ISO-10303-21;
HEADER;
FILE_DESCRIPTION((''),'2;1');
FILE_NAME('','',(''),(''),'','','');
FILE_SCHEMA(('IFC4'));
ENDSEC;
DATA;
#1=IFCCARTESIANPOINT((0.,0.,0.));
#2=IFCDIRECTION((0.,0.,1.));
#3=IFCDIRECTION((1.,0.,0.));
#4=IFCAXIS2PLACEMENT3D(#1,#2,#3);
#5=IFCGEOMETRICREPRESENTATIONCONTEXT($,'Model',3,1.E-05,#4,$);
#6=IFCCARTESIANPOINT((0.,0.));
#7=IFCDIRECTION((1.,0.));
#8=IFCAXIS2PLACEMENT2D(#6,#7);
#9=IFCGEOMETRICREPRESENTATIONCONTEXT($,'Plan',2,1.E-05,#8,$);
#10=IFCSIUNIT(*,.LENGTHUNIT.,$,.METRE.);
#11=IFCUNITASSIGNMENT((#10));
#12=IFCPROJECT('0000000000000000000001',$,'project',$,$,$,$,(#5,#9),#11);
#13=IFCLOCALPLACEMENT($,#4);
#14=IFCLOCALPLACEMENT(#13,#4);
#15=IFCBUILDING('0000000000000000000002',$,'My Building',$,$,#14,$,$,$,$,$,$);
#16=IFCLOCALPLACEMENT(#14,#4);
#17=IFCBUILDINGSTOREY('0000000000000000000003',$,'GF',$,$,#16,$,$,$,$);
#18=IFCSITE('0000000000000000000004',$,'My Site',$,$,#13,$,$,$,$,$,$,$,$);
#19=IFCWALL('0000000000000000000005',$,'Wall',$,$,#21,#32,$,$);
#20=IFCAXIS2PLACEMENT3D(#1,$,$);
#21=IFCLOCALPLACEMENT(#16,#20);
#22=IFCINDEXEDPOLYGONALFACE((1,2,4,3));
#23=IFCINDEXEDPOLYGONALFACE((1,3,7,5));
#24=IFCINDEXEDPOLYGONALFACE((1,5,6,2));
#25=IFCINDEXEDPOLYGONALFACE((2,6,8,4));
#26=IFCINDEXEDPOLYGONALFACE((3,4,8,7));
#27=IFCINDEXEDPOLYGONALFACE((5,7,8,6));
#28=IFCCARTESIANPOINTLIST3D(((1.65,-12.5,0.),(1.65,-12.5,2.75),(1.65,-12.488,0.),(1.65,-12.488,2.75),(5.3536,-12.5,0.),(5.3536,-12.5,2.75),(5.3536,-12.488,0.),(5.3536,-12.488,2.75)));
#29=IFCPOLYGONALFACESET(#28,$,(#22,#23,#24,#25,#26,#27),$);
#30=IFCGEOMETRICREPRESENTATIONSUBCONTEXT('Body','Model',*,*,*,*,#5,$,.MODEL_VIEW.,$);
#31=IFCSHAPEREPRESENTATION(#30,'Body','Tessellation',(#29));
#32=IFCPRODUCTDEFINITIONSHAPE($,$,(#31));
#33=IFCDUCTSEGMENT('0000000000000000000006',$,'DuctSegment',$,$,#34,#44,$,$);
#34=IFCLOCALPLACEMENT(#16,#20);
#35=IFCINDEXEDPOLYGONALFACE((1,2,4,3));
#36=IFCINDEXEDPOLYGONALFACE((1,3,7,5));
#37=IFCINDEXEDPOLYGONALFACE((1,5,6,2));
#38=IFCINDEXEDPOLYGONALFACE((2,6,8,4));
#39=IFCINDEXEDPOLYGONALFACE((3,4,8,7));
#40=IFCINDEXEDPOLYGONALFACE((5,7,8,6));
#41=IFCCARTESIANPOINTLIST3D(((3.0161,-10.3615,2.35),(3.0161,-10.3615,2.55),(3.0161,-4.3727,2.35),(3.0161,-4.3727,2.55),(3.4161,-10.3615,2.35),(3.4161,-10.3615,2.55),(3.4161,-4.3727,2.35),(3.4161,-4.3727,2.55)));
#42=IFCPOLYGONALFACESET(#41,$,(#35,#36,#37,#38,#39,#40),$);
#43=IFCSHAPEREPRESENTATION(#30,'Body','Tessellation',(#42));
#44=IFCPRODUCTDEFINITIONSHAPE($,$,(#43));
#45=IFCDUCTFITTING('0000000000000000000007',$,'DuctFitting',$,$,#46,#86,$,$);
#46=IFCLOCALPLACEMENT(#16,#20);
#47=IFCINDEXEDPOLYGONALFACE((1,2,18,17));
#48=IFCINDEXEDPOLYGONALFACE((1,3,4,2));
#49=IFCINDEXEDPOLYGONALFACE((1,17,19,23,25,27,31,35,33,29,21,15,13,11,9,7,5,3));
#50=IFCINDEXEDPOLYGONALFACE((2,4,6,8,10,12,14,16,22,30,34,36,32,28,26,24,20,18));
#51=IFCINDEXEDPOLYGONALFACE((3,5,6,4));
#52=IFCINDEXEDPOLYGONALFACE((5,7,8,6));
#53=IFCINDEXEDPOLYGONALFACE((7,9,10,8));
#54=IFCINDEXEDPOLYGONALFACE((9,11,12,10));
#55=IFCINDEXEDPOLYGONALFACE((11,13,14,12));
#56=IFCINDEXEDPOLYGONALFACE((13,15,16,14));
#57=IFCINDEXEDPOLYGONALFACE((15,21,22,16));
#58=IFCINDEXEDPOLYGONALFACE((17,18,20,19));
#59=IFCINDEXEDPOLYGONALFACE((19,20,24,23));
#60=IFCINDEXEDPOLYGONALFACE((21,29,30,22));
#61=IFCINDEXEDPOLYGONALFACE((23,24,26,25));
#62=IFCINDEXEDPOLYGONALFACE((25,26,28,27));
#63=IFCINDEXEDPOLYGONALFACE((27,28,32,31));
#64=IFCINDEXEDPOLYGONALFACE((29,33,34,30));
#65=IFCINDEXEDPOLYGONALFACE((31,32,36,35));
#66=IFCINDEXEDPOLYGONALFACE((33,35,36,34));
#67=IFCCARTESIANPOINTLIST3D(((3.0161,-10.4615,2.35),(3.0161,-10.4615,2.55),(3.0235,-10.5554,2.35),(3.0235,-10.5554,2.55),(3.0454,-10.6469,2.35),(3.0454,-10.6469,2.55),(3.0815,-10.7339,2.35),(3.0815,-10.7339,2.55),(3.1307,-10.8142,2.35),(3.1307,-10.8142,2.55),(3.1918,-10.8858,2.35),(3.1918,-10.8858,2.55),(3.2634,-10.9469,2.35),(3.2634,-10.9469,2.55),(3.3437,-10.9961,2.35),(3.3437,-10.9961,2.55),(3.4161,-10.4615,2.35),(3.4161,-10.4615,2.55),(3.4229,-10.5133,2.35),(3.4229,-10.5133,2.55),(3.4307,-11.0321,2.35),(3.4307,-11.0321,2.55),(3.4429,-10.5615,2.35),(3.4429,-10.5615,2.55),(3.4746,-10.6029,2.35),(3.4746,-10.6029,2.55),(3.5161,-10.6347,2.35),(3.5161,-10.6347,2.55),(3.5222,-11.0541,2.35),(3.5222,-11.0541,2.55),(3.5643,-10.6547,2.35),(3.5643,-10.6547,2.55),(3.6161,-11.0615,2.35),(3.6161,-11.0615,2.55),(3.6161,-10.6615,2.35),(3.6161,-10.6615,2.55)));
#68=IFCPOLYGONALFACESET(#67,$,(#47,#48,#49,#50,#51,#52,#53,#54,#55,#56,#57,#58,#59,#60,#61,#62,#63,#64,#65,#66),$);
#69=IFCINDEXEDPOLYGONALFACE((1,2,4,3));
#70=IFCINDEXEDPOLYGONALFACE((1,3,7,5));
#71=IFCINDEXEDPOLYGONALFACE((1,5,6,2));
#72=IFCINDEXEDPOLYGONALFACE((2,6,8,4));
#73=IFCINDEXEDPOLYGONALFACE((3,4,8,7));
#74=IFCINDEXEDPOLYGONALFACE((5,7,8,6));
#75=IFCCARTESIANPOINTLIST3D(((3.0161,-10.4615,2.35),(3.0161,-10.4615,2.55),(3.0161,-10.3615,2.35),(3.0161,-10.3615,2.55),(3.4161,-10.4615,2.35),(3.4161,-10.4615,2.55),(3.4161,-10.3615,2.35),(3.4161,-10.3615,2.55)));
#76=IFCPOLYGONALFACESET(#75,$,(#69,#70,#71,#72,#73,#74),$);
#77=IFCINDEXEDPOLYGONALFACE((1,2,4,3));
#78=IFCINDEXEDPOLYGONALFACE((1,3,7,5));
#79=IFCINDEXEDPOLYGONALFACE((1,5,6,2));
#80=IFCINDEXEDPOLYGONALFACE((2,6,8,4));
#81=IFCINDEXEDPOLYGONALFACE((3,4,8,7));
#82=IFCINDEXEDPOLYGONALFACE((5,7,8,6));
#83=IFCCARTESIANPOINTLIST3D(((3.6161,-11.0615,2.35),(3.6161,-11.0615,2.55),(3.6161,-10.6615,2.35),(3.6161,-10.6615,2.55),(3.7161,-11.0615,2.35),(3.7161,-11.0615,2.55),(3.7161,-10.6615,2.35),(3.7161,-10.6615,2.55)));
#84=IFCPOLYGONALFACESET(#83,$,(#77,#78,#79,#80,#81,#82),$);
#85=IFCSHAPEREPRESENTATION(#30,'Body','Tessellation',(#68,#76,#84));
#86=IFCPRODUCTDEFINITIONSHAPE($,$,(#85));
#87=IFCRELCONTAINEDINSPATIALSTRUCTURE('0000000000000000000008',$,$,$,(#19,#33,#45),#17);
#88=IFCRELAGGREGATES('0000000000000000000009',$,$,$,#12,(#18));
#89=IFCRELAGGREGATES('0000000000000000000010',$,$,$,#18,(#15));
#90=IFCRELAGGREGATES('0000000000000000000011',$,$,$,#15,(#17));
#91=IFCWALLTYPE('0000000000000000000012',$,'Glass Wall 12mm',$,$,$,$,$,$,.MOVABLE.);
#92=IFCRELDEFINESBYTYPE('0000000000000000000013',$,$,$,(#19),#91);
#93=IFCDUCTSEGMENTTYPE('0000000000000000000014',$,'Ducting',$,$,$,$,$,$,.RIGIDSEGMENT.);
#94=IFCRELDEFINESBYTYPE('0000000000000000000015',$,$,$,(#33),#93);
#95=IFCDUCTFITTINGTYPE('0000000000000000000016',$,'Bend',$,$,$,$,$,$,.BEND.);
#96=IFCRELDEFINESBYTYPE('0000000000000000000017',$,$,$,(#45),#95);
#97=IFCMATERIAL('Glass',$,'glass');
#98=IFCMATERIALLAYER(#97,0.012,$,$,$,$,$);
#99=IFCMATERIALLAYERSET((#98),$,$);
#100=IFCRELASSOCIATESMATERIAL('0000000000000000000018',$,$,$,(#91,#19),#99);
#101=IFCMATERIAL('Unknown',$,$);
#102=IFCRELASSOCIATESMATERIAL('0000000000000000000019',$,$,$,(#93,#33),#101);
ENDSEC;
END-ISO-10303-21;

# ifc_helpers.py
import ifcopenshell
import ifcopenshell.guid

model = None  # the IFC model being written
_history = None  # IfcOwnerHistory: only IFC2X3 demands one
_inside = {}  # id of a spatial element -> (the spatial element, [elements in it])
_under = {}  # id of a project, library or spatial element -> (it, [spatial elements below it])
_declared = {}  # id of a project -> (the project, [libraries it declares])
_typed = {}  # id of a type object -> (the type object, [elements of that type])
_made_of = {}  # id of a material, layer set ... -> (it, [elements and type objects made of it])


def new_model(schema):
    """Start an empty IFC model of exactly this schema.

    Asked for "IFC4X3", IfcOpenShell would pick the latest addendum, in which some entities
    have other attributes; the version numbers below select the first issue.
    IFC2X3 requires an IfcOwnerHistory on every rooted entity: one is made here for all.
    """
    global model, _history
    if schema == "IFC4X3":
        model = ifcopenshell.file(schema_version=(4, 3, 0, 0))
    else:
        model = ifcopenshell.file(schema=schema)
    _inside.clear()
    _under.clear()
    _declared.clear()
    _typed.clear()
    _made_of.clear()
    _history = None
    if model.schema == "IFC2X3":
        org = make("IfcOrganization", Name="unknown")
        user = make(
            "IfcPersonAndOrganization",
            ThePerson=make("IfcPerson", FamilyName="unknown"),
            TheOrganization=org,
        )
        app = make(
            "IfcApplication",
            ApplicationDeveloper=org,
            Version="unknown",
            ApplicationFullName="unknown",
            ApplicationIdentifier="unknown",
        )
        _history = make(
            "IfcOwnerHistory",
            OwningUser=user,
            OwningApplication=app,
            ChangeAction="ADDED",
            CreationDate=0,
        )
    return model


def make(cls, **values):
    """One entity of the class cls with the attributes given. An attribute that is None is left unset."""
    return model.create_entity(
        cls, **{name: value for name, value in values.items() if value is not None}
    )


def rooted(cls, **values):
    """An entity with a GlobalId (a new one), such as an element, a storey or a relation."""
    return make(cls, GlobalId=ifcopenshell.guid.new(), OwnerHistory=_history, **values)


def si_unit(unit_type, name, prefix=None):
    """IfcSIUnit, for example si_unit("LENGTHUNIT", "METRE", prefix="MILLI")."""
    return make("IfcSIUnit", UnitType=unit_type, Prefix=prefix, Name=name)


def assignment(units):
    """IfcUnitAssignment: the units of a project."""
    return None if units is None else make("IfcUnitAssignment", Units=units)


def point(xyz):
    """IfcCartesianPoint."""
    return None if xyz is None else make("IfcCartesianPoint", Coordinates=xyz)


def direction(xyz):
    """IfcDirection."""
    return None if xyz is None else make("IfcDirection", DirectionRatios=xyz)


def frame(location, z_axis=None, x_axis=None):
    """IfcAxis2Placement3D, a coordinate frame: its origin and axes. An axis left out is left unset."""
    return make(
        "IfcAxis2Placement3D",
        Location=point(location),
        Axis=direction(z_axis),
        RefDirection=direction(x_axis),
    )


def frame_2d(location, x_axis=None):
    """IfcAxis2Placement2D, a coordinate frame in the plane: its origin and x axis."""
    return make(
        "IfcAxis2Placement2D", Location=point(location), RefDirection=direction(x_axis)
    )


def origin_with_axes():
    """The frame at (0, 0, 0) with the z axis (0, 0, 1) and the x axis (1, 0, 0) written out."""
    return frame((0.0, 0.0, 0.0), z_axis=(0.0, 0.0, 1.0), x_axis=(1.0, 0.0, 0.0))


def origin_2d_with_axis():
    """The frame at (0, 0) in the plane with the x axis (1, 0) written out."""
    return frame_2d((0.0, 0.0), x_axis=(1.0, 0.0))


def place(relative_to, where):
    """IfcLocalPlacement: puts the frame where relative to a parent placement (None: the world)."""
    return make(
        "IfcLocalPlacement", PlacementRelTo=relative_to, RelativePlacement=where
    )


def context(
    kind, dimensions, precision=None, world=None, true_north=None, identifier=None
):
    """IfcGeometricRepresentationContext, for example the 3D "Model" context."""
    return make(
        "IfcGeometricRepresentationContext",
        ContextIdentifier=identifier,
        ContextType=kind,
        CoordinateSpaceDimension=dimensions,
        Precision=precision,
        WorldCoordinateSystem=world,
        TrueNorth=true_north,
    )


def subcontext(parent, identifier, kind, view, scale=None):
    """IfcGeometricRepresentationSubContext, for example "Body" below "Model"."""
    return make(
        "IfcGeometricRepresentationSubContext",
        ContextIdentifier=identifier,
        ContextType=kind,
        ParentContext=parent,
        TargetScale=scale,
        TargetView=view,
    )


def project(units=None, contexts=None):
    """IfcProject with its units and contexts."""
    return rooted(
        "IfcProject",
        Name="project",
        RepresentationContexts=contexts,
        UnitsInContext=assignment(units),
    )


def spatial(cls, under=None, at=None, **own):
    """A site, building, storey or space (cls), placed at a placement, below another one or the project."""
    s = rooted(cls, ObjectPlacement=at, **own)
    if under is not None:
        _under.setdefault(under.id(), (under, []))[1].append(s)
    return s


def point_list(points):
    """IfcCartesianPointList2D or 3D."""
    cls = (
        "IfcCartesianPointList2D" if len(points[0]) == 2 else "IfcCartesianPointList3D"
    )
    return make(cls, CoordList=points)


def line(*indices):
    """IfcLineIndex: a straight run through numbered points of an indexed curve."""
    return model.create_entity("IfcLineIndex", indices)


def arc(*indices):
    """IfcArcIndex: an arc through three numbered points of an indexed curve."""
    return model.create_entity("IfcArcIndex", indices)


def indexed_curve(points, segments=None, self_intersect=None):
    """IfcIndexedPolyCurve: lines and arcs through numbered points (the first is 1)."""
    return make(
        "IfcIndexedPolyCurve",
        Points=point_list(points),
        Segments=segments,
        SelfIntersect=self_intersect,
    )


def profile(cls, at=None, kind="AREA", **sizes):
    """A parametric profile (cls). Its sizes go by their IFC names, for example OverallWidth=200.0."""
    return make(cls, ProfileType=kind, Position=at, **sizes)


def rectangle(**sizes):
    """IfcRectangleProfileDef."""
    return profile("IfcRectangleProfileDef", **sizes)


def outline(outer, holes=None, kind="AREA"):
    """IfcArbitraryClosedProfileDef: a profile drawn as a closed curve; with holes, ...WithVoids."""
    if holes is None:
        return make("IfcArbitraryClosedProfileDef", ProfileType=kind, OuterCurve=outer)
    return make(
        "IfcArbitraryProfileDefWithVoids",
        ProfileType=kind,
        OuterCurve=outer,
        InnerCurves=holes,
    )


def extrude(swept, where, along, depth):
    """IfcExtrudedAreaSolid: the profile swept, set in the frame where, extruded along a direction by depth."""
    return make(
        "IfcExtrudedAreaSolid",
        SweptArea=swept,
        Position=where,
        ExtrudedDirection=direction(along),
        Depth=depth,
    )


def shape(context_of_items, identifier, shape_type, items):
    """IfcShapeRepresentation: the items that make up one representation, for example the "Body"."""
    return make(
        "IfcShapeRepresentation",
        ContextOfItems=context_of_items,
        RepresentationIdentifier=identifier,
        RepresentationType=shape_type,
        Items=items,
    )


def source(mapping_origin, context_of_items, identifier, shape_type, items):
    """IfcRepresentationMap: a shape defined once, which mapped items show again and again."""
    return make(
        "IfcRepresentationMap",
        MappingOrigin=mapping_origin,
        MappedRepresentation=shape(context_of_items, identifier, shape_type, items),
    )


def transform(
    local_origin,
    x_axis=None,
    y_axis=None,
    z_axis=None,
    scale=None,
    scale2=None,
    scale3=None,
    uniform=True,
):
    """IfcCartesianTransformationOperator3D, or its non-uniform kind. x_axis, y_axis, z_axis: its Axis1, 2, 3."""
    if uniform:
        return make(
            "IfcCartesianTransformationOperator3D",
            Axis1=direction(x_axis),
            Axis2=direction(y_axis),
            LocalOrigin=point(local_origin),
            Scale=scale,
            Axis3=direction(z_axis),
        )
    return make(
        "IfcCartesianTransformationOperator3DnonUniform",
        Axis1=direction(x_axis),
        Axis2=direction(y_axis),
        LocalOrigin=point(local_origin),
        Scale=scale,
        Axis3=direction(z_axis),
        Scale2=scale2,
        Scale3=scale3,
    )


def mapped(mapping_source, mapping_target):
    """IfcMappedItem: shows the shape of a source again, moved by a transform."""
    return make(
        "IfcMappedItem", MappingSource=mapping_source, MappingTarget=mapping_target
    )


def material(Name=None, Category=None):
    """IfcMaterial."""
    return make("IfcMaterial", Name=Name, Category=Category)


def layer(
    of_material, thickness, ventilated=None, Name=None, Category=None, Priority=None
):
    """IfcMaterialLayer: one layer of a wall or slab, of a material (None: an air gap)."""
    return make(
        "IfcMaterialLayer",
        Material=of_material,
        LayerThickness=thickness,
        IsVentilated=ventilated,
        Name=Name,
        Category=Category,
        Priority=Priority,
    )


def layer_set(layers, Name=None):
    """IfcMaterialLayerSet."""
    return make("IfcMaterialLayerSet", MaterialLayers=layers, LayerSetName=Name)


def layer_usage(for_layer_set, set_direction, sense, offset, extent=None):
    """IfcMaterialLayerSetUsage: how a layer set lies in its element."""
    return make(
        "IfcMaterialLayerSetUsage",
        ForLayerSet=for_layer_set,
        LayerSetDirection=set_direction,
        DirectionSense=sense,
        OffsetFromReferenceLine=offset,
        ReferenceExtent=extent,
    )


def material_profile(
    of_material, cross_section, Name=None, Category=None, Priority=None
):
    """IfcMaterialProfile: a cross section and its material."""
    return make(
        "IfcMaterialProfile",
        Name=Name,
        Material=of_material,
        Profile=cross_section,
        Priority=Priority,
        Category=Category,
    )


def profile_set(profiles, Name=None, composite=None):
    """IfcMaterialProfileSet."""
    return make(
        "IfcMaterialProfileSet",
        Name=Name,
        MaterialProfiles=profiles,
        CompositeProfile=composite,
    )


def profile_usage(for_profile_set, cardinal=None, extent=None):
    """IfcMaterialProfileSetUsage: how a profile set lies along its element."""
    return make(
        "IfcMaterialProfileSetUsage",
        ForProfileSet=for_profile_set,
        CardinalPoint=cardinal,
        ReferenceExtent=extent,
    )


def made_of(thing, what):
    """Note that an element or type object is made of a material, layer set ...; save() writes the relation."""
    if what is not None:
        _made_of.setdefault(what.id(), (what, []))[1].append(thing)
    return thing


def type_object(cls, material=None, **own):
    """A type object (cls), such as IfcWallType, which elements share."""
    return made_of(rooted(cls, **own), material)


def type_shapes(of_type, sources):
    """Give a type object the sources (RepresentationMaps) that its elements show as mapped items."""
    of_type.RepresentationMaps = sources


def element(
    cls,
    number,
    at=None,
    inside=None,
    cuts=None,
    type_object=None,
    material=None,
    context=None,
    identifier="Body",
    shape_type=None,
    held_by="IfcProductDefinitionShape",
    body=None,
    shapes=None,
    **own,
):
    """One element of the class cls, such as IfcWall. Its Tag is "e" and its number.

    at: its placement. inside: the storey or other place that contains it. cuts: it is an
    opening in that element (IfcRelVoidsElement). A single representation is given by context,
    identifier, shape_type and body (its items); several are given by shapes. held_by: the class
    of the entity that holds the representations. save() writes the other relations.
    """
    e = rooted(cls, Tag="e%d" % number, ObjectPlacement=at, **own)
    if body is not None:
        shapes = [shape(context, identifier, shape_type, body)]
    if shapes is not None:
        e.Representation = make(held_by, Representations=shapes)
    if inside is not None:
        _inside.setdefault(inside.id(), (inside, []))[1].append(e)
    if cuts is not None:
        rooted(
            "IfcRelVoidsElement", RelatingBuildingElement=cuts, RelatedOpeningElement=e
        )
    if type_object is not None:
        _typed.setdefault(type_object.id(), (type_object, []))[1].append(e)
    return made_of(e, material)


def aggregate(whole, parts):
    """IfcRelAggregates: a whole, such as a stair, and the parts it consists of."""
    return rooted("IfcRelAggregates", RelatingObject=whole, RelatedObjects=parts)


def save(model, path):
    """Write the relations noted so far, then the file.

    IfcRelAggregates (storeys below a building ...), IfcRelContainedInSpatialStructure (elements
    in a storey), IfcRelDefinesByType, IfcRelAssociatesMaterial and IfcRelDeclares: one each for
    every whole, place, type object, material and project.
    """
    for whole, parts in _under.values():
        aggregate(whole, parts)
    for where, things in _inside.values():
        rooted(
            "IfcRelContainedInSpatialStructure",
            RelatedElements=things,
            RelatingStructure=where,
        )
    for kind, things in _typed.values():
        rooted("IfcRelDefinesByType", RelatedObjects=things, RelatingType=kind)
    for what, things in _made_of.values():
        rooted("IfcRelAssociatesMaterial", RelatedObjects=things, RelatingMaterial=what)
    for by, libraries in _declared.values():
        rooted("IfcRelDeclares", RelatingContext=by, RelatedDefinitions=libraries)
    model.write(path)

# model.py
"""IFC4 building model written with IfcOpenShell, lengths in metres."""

from ifc_helpers import new_model, si_unit, frame, origin_with_axes, origin_2d_with_axis, place, context, subcontext, project, spatial, line, arc, indexed_curve, rectangle, outline, extrude, source, transform, mapped, material, layer, layer_set, layer_usage, material_profile, profile_set, profile_usage, type_object, type_shapes, element, save


model = new_model("IFC4")

# Units and contexts
model_context = context("Model", 3, precision=1e-05, world=origin_with_axes())
plan_context = context("Plan", 2, precision=1e-05, world=origin_2d_with_axis())
body_context_1 = subcontext(model_context, "Body", "Model", "MODEL_VIEW")
ifc_project = project(units=[si_unit("LENGTHUNIT", "METRE")], contexts=[model_context, plan_context])

# Site, building, storey
site_placement = place(None, origin_with_axes())
site = spatial("IfcSite", under=ifc_project, at=site_placement, Name="My Site")
building_placement = place(site_placement, origin_with_axes())
building = spatial("IfcBuilding", under=site, at=building_placement, Name="My Building")
storey_placement = place(building_placement, origin_with_axes())
storey = spatial("IfcBuildingStorey", under=building, at=storey_placement, Name="GF")

# Shared definitions
ifc_material_1 = material(Name="Unknown")

# Wall
ifc_material_2 = material(Name="Glass", Category="glass")
ifc_layer_1 = layer(ifc_material_2, 0.012)
ifc_layer_set_1 = layer_set([ifc_layer_1])
ifc_layer_usage_1 = layer_usage(ifc_layer_set_1, "AXIS2", "POSITIVE", 0.0)
wall_type_1 = type_object("IfcWallType", Name="Glass Wall 12mm", PredefinedType="MOVABLE", material=ifc_layer_set_1)
wall_1_placement = place(storey_placement, frame((1.65, -12.5, 0.0), z_axis=(0.0, 0.0, 1.0), x_axis=(1.0, 0.0, 0.0)))
element("IfcWall", 1, at=wall_1_placement, inside=storey, type_object=wall_type_1, material=ifc_layer_usage_1, Name="Wall", context=body_context_1, shape_type="SweptSolid", body=[
    extrude(outline(indexed_curve([(0.0, 0.0), (0.0, 0.012), (3.7036, 0.012), (3.7036, 0.0)], segments=[line(1, 2, 3, 4, 1)])), origin_with_axes(), (0.0, 0.0, 1.0), 2.75),
])

# Duct segment
ifc_material_profile_1 = material_profile(ifc_material_1, rectangle(XDim=0.4, YDim=0.2))
ifc_profile_set_1 = profile_set([ifc_material_profile_1])
ifc_profile_usage_1 = profile_usage(ifc_profile_set_1, cardinal=4)
duct_segment_type = type_object("IfcDuctSegmentType", Name="Ducting", PredefinedType="RIGIDSEGMENT", material=ifc_profile_set_1)
duct_segment_placement = place(storey_placement, frame((3.0161, -10.3615, 2.45), z_axis=(0.0, 1.0, 0.0), x_axis=(-1.0, 0.0, 0.0)))
element("IfcDuctSegment", 2, at=duct_segment_placement, inside=storey, type_object=duct_segment_type, material=ifc_profile_usage_1, Name="DuctSegment", context=body_context_1, shape_type="SweptSolid", body=[
    extrude(rectangle(XDim=0.4, YDim=0.2), frame((-0.2, 0.0, 0.0), z_axis=(0.0, 0.0, 1.0), x_axis=(1.0, 0.0, 0.0)), (0.0, 0.0, 1.0), 5.9888),
])

# Duct fitting
duct_fitting_type = type_object("IfcDuctFittingType", Name="Bend", PredefinedType="BEND")
shared_shape_1 = source(origin_with_axes(), body_context_1, "Body", "SweptSolid", [
    extrude(outline(indexed_curve([(-0.2, 0.0), (-0.2586, -0.1414), (-0.4, -0.2), (-0.4, -0.6), (0.0243, -0.4243), (0.2, 0.0)], segments=[arc(1, 2, 3), line(3, 4), arc(4, 5, 6), line(6, 1)])), frame((0.0, -0.1, -0.1), z_axis=(0.0, -1.0, 0.0), x_axis=(1.0, 0.0, 0.0)), (0.0, 0.0, -1.0), 0.2),
    extrude(rectangle(XDim=0.4, YDim=0.2), origin_with_axes(), (0.0, 0.0, -1.0), 0.1),
    extrude(rectangle(XDim=0.4, YDim=0.2), frame((-0.4, 0.0, -0.5), z_axis=(-1.0, 0.0, 0.0), x_axis=(0.0, 0.0, -1.0)), (0.0, 0.0, 1.0), 0.1),
])
type_shapes(duct_fitting_type, [shared_shape_1])
duct_fitting_placement = place(storey_placement, frame((3.2161, -10.3615, 2.45), z_axis=(0.0, 1.0, 0.0), x_axis=(-1.0, 0.0, 0.0)))
element("IfcDuctFitting", 3, at=duct_fitting_placement, inside=storey, type_object=duct_fitting_type, Name="DuctFitting", context=body_context_1, shape_type="MappedRepresentation", body=[
    mapped(shared_shape_1, transform((0.0, 0.0, 0.0), x_axis=(1.0, 0.0, 0.0), y_axis=(0.0, 1.0, 0.0), z_axis=(0.0, 0.0, 1.0), scale=1.0)),
])

save(model, "model.ifc")
